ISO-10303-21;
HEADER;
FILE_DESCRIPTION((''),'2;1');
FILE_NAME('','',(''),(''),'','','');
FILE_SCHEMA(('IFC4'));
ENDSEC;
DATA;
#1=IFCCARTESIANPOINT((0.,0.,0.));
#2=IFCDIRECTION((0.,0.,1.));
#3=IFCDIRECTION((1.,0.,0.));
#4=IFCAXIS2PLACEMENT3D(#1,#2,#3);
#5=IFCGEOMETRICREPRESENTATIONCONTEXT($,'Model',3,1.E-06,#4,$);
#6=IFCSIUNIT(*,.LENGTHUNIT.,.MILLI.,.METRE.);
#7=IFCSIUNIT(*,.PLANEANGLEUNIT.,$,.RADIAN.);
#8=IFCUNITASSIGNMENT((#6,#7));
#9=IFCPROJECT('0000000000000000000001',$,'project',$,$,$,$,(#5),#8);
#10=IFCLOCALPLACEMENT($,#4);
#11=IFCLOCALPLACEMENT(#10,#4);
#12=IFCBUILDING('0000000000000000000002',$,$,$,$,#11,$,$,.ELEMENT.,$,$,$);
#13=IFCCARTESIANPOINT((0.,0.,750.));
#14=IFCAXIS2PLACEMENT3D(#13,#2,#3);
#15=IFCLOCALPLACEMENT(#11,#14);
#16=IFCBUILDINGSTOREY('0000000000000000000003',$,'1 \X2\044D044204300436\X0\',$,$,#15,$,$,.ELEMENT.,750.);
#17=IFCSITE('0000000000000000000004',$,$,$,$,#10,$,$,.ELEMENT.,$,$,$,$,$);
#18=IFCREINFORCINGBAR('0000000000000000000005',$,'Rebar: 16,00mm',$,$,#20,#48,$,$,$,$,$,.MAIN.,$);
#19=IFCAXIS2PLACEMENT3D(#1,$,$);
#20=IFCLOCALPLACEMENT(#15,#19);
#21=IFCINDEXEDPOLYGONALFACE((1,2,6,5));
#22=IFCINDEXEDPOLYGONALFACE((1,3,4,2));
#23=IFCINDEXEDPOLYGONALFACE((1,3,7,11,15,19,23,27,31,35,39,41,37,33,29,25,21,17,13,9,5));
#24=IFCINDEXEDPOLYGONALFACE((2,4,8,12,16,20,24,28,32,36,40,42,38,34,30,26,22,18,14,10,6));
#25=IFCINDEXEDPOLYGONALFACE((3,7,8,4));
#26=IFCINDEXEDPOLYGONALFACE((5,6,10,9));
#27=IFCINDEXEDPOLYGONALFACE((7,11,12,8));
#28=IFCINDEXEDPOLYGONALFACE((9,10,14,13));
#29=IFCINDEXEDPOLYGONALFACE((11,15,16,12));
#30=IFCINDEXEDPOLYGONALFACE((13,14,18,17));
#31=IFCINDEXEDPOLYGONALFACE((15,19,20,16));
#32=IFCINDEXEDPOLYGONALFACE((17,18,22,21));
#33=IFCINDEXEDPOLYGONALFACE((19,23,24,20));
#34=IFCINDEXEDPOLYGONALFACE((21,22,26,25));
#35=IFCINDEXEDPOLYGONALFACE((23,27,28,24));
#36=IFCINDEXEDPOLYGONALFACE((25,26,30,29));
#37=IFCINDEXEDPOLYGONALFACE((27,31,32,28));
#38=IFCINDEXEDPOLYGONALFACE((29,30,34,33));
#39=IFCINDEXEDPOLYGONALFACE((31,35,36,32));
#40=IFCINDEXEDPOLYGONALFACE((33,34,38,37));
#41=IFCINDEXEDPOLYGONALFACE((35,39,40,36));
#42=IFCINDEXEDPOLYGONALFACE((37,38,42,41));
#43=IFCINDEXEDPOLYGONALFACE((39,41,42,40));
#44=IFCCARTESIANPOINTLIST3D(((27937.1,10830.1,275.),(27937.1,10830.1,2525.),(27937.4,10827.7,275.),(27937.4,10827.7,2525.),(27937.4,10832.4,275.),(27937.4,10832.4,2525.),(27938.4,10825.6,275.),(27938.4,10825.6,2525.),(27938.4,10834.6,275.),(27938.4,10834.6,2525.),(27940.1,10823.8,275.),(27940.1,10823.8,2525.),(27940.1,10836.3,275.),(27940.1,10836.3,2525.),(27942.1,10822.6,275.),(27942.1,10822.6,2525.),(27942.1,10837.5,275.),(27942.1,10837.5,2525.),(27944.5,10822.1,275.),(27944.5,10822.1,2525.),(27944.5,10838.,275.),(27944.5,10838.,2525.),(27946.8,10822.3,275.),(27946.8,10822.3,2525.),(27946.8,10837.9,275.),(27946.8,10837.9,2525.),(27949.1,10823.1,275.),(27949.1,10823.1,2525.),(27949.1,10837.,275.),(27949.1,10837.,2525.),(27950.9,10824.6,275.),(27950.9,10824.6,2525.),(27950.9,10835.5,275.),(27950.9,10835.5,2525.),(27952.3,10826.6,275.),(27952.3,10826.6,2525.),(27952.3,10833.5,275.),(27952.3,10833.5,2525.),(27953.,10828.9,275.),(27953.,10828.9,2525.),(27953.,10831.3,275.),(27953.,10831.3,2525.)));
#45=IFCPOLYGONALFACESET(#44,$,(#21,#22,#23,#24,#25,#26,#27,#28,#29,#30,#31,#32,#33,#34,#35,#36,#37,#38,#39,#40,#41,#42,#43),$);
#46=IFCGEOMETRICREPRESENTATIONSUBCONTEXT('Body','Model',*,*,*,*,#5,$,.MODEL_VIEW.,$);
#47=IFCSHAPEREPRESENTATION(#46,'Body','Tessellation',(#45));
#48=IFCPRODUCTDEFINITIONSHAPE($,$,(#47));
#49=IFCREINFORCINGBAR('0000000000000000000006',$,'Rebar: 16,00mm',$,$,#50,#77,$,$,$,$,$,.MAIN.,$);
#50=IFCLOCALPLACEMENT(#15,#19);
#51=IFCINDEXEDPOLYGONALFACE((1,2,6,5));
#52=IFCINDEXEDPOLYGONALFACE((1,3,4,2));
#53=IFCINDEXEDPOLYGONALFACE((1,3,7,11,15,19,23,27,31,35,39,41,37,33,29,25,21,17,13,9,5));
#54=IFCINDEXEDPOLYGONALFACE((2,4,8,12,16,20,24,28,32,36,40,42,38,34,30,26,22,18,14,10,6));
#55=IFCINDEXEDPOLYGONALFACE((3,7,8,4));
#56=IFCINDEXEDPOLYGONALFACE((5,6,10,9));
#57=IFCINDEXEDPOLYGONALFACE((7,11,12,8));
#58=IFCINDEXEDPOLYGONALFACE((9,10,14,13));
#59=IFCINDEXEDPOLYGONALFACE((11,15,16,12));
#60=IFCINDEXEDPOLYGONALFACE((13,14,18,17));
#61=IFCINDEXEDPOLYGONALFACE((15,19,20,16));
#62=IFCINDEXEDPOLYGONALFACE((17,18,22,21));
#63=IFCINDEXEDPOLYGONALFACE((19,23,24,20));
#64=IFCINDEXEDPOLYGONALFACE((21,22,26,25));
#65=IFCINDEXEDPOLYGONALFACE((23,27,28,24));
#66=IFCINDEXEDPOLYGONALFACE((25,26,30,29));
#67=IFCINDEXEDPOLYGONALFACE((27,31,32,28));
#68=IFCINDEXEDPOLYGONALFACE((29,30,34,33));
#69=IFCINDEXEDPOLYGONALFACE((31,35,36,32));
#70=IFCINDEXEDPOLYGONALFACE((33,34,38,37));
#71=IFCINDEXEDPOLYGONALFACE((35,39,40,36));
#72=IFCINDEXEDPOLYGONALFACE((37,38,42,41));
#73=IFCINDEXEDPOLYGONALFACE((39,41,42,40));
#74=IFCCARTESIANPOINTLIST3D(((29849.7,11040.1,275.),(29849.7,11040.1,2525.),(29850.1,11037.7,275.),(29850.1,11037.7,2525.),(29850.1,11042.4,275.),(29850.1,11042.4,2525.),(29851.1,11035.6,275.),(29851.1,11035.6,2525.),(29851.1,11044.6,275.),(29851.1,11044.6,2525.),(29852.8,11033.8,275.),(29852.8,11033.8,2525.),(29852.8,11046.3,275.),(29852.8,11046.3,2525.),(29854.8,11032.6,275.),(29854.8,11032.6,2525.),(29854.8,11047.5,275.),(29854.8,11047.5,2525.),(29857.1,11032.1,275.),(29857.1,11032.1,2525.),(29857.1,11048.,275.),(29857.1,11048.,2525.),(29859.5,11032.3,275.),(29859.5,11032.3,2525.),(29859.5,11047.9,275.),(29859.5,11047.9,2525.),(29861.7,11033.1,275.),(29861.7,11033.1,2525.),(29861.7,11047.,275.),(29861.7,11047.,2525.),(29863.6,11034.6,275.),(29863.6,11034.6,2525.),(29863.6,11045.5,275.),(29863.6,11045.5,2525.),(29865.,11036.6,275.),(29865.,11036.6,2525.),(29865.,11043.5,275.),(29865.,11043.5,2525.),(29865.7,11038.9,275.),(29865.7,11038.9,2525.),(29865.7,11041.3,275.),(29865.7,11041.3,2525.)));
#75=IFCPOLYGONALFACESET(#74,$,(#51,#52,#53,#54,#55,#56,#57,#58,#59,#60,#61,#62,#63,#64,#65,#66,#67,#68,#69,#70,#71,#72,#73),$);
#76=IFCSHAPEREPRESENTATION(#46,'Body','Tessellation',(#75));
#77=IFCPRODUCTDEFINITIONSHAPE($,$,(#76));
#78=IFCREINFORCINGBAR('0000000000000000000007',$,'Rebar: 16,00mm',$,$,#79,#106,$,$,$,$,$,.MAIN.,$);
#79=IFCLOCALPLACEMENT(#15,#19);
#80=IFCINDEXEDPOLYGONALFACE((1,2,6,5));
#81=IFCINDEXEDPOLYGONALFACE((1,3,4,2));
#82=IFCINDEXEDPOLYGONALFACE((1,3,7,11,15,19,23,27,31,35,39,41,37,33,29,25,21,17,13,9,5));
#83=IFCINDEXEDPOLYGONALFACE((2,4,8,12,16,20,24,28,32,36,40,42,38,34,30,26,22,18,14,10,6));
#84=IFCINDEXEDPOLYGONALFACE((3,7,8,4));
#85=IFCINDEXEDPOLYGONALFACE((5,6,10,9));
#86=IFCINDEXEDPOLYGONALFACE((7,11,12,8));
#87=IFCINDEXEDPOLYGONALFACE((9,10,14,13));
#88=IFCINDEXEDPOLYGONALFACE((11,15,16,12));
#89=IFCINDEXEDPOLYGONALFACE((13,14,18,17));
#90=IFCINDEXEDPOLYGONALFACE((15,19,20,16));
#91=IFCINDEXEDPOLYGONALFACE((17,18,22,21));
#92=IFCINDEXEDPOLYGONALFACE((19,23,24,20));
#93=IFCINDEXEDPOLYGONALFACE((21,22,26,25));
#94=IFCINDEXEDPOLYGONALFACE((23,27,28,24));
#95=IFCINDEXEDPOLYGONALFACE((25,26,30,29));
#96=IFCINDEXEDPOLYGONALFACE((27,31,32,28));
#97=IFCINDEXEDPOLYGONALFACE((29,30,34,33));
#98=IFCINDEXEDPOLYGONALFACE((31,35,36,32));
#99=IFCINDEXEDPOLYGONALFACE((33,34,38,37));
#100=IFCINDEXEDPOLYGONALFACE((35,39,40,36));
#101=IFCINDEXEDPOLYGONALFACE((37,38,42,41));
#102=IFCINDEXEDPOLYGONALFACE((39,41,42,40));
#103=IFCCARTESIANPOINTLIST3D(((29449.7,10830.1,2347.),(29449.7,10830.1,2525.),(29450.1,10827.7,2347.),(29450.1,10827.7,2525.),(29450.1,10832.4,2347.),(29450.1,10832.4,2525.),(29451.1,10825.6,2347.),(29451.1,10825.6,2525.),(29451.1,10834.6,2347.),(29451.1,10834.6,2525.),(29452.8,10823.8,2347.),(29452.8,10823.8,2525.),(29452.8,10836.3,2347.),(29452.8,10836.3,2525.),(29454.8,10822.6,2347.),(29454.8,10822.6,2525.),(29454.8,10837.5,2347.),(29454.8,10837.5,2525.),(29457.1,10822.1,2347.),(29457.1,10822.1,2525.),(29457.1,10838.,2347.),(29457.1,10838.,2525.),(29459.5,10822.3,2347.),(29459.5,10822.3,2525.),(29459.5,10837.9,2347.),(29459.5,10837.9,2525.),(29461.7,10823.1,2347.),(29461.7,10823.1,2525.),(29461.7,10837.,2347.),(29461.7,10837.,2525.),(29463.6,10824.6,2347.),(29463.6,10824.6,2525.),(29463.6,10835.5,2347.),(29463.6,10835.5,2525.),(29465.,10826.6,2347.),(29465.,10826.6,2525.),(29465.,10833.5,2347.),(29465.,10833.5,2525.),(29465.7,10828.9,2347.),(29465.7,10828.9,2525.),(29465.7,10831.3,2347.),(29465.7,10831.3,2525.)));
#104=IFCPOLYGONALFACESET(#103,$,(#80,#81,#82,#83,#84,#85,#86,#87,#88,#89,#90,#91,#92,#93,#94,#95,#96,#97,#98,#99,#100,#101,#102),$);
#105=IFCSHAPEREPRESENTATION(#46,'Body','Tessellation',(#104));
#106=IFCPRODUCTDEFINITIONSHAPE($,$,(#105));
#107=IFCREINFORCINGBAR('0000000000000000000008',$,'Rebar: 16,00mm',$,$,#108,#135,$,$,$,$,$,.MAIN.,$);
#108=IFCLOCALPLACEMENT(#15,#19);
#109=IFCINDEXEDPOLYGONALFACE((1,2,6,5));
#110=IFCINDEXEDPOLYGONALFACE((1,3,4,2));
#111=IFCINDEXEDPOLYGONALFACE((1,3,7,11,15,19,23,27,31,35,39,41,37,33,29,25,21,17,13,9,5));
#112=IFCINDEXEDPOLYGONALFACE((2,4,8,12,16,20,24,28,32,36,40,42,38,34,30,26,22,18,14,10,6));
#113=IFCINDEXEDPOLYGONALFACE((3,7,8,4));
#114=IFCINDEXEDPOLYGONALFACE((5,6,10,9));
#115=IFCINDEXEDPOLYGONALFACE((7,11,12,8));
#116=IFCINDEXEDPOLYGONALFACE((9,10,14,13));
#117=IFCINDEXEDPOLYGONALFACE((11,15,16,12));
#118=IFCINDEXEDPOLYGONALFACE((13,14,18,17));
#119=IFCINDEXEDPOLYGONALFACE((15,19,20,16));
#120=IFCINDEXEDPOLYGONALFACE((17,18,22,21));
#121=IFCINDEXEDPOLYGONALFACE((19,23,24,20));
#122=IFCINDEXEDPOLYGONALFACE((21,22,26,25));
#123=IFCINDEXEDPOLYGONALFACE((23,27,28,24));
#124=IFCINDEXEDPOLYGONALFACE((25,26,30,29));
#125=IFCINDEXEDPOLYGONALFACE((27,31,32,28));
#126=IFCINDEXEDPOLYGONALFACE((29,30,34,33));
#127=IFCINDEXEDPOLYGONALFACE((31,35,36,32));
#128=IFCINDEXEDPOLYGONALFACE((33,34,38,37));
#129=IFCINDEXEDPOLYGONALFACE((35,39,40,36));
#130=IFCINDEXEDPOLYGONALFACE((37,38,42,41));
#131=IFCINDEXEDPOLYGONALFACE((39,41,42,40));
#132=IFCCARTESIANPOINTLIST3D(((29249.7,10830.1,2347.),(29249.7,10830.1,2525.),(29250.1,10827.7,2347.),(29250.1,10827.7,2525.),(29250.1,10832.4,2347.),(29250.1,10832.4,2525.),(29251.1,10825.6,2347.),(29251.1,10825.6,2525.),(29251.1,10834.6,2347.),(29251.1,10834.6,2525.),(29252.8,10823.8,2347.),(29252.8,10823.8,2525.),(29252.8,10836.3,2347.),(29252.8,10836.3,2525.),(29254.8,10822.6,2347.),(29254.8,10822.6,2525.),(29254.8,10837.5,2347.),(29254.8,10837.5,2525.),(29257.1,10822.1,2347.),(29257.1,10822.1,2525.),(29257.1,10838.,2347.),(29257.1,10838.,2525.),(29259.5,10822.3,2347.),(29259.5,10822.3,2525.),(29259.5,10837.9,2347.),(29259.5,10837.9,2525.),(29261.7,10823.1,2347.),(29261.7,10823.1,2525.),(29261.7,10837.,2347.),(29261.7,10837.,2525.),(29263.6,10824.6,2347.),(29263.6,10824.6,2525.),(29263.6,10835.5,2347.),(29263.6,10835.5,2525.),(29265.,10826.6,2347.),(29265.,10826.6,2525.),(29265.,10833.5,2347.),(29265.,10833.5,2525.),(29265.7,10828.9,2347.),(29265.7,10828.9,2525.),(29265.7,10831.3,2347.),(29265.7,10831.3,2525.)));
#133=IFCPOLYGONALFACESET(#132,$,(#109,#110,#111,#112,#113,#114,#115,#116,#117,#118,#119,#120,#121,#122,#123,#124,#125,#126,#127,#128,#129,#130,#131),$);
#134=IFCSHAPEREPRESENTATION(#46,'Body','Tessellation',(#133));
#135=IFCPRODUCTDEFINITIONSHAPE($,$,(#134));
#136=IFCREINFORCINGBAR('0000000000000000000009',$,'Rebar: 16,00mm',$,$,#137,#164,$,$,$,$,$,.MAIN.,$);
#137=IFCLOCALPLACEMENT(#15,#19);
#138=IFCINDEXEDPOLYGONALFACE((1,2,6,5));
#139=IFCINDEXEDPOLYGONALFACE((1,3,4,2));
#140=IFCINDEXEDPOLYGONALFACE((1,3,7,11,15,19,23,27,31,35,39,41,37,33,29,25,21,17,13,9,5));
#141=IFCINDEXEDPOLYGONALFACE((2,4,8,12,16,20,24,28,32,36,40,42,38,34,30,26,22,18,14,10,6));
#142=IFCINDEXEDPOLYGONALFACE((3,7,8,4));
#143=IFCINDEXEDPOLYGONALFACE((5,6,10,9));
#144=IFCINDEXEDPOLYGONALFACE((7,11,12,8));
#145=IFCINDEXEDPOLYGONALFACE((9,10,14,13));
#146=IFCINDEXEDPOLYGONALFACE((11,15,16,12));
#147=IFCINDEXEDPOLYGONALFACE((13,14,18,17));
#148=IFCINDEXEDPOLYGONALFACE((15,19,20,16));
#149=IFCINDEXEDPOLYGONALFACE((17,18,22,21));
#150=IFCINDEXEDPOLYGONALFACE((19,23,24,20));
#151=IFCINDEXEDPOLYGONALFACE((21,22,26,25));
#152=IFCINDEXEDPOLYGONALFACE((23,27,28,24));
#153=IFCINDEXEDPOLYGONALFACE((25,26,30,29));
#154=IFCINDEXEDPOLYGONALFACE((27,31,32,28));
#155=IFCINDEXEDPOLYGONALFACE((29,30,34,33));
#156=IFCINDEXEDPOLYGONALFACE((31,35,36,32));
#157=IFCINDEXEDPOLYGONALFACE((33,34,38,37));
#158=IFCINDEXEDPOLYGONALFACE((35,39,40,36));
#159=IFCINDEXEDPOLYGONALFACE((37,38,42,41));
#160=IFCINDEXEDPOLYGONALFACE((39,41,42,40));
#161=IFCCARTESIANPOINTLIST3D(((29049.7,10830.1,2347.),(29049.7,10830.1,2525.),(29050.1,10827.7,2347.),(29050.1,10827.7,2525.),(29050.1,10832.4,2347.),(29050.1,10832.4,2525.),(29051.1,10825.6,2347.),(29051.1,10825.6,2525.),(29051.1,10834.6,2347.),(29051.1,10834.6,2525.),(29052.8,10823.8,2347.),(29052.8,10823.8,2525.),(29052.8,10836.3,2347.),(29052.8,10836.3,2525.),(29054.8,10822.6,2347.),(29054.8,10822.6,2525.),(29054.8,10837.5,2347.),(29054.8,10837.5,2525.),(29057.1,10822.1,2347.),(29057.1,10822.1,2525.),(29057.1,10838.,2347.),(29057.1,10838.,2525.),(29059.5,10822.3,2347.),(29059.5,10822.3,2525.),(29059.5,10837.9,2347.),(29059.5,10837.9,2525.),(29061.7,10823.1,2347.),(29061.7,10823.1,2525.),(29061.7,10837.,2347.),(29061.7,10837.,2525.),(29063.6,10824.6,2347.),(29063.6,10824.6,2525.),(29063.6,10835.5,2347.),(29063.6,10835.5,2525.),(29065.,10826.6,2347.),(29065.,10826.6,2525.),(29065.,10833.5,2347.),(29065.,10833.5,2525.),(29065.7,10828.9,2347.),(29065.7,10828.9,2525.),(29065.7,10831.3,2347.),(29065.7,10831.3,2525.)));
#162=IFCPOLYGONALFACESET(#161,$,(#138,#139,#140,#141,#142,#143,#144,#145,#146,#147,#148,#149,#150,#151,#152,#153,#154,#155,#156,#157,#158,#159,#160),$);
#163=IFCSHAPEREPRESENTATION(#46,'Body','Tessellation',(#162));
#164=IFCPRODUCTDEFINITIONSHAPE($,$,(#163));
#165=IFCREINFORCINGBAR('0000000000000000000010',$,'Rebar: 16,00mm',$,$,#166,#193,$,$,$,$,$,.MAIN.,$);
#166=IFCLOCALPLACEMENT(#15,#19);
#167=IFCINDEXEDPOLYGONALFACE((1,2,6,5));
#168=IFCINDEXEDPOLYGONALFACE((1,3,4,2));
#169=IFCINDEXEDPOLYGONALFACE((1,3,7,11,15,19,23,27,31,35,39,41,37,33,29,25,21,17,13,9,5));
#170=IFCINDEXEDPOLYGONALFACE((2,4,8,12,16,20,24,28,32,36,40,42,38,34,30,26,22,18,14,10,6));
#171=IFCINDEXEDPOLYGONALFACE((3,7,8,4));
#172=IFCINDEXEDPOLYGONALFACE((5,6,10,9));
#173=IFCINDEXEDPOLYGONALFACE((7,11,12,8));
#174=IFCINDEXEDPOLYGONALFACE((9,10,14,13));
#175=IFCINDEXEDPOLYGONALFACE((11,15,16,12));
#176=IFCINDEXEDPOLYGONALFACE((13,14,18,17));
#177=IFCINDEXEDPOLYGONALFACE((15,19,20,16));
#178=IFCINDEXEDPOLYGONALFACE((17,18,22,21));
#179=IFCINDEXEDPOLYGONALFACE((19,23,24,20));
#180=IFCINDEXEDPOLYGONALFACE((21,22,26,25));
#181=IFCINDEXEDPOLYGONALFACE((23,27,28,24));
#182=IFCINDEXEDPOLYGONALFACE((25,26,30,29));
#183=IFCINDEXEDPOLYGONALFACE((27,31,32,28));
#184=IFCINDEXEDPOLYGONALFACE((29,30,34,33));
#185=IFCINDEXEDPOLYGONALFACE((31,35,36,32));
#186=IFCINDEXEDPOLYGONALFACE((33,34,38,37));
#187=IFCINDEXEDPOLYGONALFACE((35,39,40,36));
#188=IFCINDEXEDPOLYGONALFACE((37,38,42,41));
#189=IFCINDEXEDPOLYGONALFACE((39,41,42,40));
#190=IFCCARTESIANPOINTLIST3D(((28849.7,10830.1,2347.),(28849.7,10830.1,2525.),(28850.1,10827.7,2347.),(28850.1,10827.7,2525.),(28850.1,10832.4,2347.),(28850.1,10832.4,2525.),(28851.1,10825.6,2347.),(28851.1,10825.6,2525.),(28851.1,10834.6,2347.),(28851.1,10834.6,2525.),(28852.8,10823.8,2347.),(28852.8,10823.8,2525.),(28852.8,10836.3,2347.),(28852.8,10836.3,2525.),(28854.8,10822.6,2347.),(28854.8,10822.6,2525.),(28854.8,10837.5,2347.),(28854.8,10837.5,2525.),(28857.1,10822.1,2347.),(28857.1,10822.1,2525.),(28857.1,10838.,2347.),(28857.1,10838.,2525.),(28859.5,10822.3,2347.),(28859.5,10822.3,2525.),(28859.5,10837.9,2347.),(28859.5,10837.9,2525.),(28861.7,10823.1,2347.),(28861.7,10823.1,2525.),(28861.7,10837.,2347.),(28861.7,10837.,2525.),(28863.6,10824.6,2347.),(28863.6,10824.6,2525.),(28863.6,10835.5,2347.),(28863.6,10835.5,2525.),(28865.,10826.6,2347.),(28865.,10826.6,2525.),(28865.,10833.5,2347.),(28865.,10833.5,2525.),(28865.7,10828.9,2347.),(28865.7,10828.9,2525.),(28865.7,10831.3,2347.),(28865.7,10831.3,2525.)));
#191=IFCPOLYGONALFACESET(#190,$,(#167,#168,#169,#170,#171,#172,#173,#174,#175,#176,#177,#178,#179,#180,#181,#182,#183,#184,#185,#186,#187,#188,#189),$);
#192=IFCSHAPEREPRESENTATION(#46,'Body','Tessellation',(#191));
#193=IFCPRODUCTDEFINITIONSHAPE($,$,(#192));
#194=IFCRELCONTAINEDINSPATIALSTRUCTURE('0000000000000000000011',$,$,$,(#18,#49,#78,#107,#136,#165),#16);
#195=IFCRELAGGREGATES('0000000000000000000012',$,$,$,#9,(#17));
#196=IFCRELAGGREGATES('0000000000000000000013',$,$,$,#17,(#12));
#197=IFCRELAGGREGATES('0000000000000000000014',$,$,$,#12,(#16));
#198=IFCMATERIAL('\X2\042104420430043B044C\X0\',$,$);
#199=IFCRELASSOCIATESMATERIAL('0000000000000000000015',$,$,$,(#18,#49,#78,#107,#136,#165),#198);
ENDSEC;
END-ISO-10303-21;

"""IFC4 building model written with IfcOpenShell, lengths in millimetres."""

from ifc_helpers import new_model, entity, si_unit, frame, origin_with_axes, place, context, subcontext, project, spatial, source, transform, mapped, material, element, save


model = new_model("IFC4")

# Units and contexts
model_context = context("Model", 3, precision=1e-06, world=origin_with_axes())
body_context = subcontext(model_context, "Body", "Model", "MODEL_VIEW")
ifc_project = project(units=[si_unit("LENGTHUNIT", "METRE", prefix="MILLI"), si_unit("PLANEANGLEUNIT", "RADIAN")], contexts=[model_context])

# Site, building, storey
site_placement = place(None, origin_with_axes())
site = spatial("IfcSite", under=ifc_project, at=site_placement, CompositionType="ELEMENT")
building_placement = place(site_placement, origin_with_axes())
building = spatial("IfcBuilding", under=site, at=building_placement, CompositionType="ELEMENT")
storey_placement = place(building_placement, frame((0.0, 0.0, 750.0), z_axis=(0.0, 0.0, 1.0), x_axis=(1.0, 0.0, 0.0)))
storey = spatial("IfcBuildingStorey", under=building, at=storey_placement, Name="1 этаж", CompositionType="ELEMENT", Elevation=750.0)

# Reinforcing bars
ifc_material = material(Name="Сталь")
shared_shape_1 = source(origin_with_axes(), body_context, "Body", "AdvancedSweptSolid", [
    entity("IfcSweptDiskSolid", entity("IfcIndexedPolyCurve", entity("IfcCartesianPointList3D", [[0.0, 0.0, 0.0], [2250.0, 0.0, 0.0]]), [entity("IfcLineIndex", [1, 2])]), 8.0),
])
reinforcing_bar_1_placement = place(storey_placement, origin_with_axes())
element("IfcReinforcingBar", 1, at=reinforcing_bar_1_placement, inside=storey, material=ifc_material, Name="Rebar: 16,00mm", PredefinedType="MAIN", context=body_context, shape_type="MappedRepresentation", body=[
    mapped(shared_shape_1, transform((27945.1, 10830.1, 275.0), x_axis=(0.0, 0.0, 1.0), y_axis=(0.0, 1.0, 0.0), z_axis=(-1.0, 0.0, 0.0), scale=1.0)),
])
reinforcing_bar_2_placement = place(storey_placement, origin_with_axes())
element("IfcReinforcingBar", 2, at=reinforcing_bar_2_placement, inside=storey, material=ifc_material, Name="Rebar: 16,00mm", PredefinedType="MAIN", context=body_context, shape_type="MappedRepresentation", body=[
    mapped(shared_shape_1, transform((29857.7, 11040.1, 275.0), x_axis=(0.0, 0.0, 1.0), y_axis=(0.0, 1.0, 0.0), z_axis=(-1.0, 0.0, 0.0), scale=1.0)),
])
shared_shape_2 = source(origin_with_axes(), body_context, "Body", "AdvancedSweptSolid", [
    entity("IfcSweptDiskSolid", entity("IfcIndexedPolyCurve", entity("IfcCartesianPointList3D", [[0.0, 0.0, 0.0], [178.0, 0.0, 0.0]]), [entity("IfcLineIndex", [1, 2])]), 8.0),
])
reinforcing_bar_3_placement = place(storey_placement, origin_with_axes())
element("IfcReinforcingBar", 3, at=reinforcing_bar_3_placement, inside=storey, material=ifc_material, Name="Rebar: 16,00mm", PredefinedType="MAIN", context=body_context, shape_type="MappedRepresentation", body=[
    mapped(shared_shape_2, transform((29457.7, 10830.1, 2347.0), x_axis=(0.0, 0.0, 1.0), y_axis=(0.0, 1.0, 0.0), z_axis=(-1.0, 0.0, 0.0), scale=1.0)),
])
reinforcing_bar_4_placement = place(storey_placement, origin_with_axes())
element("IfcReinforcingBar", 4, at=reinforcing_bar_4_placement, inside=storey, material=ifc_material, Name="Rebar: 16,00mm", PredefinedType="MAIN", context=body_context, shape_type="MappedRepresentation", body=[
    mapped(shared_shape_2, transform((29257.7, 10830.1, 2347.0), x_axis=(0.0, 0.0, 1.0), y_axis=(0.0, 1.0, 0.0), z_axis=(-1.0, 0.0, 0.0), scale=1.0)),
])
reinforcing_bar_5_placement = place(storey_placement, origin_with_axes())
element("IfcReinforcingBar", 5, at=reinforcing_bar_5_placement, inside=storey, material=ifc_material, Name="Rebar: 16,00mm", PredefinedType="MAIN", context=body_context, shape_type="MappedRepresentation", body=[
    mapped(shared_shape_2, transform((29057.7, 10830.1, 2347.0), x_axis=(0.0, 0.0, 1.0), y_axis=(0.0, 1.0, 0.0), z_axis=(-1.0, 0.0, 0.0), scale=1.0)),
])
reinforcing_bar_6_placement = place(storey_placement, origin_with_axes())
element("IfcReinforcingBar", 6, at=reinforcing_bar_6_placement, inside=storey, material=ifc_material, Name="Rebar: 16,00mm", PredefinedType="MAIN", context=body_context, shape_type="MappedRepresentation", body=[
    mapped(shared_shape_2, transform((28857.7, 10830.1, 2347.0), x_axis=(0.0, 0.0, 1.0), y_axis=(0.0, 1.0, 0.0), z_axis=(-1.0, 0.0, 0.0), scale=1.0)),
])

save(model, "model.ifc")
